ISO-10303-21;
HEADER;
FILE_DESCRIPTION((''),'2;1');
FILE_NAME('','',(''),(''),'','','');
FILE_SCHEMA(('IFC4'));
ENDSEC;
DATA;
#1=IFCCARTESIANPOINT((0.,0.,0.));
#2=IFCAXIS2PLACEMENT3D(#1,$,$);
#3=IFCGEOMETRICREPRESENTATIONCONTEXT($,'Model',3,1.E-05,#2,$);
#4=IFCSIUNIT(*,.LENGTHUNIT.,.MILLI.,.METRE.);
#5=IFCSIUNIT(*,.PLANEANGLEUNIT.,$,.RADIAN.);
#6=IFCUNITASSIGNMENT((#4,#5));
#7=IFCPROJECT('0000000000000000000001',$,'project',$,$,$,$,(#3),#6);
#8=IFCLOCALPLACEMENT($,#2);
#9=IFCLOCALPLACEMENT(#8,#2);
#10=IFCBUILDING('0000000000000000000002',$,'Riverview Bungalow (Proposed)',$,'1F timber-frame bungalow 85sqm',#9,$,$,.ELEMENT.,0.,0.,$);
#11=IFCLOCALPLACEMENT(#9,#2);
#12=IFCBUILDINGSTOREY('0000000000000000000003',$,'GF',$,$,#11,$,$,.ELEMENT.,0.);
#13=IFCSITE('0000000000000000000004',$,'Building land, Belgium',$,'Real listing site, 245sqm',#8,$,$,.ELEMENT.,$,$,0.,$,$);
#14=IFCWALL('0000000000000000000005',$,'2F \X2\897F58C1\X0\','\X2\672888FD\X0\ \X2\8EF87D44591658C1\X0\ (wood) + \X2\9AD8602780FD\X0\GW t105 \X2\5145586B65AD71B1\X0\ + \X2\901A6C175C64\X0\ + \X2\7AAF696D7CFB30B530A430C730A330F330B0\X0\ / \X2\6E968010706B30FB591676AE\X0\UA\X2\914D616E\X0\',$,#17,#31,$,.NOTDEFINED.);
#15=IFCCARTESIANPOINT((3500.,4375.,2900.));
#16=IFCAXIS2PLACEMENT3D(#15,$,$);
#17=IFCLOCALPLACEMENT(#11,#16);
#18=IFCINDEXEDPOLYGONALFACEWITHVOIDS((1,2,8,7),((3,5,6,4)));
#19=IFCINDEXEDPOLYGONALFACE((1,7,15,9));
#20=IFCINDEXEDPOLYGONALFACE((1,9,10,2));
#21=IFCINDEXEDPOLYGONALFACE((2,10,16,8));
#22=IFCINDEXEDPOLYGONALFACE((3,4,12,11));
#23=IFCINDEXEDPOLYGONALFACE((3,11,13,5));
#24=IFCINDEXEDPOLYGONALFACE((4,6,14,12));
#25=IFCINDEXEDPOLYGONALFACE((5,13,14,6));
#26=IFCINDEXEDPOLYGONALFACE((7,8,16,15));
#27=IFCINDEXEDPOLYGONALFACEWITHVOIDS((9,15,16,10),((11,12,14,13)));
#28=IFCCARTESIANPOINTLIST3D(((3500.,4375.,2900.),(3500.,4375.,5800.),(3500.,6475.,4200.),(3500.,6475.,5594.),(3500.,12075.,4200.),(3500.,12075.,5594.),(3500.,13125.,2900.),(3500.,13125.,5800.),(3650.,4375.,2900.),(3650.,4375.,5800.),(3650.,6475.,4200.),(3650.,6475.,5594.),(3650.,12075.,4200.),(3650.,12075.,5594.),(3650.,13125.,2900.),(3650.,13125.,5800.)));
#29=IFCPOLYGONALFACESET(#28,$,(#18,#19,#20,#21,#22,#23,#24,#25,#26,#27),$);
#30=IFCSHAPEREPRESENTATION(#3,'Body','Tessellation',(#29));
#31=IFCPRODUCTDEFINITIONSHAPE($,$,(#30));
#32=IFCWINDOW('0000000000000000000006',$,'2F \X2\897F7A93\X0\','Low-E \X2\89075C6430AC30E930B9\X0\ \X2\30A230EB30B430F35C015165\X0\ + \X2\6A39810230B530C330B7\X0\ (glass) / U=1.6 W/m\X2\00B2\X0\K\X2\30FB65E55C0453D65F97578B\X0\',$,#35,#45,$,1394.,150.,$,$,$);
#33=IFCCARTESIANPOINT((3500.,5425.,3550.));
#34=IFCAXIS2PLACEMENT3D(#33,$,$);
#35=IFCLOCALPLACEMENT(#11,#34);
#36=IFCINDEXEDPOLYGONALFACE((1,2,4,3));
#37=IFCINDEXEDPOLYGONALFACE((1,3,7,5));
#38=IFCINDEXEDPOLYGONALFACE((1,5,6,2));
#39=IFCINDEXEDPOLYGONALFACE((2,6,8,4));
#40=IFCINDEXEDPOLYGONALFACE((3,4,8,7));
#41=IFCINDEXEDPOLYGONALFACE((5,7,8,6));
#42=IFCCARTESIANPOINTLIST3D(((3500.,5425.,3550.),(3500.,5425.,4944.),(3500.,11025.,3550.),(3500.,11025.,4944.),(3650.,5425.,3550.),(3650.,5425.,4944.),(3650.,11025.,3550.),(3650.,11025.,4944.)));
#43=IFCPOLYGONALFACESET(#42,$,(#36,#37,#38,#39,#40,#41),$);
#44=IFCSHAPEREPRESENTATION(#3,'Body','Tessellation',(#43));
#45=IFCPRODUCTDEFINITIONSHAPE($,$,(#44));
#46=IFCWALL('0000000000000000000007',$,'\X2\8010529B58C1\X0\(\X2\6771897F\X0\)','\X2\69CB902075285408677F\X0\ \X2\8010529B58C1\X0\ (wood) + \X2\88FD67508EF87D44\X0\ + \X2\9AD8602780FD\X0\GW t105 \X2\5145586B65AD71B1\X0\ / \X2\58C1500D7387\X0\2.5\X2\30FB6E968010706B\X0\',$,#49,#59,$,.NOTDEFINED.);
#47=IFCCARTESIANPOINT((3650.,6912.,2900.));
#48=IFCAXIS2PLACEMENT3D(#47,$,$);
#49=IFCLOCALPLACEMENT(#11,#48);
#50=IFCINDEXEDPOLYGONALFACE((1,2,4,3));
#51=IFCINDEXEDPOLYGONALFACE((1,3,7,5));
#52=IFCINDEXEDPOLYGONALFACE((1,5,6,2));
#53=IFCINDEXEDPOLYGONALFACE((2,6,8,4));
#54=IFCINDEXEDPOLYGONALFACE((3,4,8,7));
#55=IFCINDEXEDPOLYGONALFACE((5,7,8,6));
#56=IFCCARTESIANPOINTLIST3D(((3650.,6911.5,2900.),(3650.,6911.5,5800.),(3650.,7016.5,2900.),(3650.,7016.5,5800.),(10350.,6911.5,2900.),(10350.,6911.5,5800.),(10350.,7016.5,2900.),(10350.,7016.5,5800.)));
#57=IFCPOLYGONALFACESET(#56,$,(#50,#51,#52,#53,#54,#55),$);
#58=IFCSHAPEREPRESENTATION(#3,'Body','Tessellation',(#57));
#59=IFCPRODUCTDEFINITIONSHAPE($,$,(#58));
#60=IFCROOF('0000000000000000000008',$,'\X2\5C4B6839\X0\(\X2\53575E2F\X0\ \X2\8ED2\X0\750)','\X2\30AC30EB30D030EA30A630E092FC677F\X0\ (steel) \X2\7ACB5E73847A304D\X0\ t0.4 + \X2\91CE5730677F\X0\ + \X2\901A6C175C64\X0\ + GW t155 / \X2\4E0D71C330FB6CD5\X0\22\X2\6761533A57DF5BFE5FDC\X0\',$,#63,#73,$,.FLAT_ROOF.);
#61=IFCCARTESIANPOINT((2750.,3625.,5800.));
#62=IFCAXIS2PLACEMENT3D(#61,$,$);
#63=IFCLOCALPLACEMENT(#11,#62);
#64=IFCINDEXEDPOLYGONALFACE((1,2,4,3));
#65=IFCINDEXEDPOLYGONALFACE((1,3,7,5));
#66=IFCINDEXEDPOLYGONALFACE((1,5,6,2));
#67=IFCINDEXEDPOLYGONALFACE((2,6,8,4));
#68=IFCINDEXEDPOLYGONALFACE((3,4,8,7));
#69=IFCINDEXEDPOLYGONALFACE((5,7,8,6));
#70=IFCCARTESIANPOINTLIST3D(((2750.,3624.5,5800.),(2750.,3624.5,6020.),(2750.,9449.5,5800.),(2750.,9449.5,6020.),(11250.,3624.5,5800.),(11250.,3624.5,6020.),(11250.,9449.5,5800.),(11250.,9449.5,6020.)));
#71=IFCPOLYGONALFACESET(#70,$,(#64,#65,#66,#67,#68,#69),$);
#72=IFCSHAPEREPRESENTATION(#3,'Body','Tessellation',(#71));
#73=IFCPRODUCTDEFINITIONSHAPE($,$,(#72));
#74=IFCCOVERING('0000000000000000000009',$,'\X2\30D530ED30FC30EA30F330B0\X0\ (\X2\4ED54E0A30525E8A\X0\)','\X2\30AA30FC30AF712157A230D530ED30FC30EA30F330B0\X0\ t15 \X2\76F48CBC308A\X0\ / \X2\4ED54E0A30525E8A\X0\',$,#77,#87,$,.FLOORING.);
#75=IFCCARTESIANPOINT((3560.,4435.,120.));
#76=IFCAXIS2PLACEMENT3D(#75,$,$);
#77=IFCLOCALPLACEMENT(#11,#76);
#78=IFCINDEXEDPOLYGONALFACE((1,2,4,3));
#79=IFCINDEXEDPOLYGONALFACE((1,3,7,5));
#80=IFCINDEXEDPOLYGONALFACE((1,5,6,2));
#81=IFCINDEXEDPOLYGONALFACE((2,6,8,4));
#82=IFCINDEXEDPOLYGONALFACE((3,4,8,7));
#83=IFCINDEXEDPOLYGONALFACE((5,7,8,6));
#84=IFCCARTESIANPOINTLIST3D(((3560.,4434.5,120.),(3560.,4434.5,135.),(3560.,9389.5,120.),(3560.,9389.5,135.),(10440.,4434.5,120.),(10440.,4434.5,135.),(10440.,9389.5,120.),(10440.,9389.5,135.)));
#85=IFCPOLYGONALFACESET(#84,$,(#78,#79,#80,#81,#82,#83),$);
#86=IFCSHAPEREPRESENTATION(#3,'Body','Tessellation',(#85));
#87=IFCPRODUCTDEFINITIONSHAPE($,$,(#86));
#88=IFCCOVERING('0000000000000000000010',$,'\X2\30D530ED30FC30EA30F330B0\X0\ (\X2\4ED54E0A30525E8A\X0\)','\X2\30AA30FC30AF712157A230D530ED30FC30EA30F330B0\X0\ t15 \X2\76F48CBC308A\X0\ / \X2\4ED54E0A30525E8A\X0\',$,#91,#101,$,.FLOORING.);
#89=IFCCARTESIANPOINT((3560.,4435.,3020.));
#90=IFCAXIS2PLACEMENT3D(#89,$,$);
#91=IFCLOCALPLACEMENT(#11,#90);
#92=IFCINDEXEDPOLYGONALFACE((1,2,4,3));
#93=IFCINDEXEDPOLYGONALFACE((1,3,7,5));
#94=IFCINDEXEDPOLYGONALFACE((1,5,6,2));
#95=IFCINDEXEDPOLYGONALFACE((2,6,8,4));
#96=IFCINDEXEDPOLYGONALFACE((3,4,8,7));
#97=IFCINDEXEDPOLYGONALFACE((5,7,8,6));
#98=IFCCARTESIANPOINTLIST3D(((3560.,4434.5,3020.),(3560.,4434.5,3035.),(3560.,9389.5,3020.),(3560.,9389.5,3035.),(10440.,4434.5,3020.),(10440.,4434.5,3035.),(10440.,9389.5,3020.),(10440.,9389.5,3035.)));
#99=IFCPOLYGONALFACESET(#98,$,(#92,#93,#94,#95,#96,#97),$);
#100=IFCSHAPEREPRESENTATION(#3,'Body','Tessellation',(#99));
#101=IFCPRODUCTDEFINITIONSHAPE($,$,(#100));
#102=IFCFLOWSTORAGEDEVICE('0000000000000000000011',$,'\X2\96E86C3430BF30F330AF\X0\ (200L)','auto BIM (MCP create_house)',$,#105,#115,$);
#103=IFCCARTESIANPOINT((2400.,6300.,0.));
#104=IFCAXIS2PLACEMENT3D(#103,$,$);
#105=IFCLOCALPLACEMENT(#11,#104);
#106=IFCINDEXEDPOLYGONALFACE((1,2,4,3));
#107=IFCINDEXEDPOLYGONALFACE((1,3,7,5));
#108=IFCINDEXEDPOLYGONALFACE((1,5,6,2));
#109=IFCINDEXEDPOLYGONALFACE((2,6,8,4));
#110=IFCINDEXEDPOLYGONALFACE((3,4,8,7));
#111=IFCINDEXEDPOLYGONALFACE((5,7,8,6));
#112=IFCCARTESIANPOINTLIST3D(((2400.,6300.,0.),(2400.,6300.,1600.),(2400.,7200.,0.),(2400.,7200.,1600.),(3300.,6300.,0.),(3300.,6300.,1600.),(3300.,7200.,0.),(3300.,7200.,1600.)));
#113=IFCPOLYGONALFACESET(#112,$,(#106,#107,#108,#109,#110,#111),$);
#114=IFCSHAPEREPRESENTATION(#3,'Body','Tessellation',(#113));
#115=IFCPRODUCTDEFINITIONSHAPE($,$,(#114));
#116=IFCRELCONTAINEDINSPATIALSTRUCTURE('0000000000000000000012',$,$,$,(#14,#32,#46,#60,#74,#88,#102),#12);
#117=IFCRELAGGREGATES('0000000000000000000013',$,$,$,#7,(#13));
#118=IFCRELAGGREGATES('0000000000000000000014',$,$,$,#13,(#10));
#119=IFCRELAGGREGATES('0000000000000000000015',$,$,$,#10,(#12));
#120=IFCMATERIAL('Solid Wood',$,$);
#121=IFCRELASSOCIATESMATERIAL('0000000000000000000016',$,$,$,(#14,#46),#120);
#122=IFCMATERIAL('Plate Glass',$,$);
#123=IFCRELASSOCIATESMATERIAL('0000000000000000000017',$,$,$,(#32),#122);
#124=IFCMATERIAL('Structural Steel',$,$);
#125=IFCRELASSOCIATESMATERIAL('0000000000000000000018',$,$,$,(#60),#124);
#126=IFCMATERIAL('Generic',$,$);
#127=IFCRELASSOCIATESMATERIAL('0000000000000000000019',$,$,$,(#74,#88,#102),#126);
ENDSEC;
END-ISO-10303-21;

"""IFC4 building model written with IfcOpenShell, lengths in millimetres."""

from ifc_helpers import new_model, si_unit, frame, frame_2d, origin, place, context, project, spatial, rectangle, extrude, material, element, fill, save


model = new_model("IFC4")

# Units and contexts
model_context = context("Model", 3, precision=1e-05, world=origin())
ifc_project = project(units=[si_unit("LENGTHUNIT", "METRE", prefix="MILLI"), si_unit("PLANEANGLEUNIT", "RADIAN")], contexts=[model_context])

# Site, building, storey
site_placement = place(None, origin())
site = spatial("IfcSite", under=ifc_project, at=site_placement, Name="Building land, Belgium", ObjectType="Real listing site, 245sqm", CompositionType="ELEMENT", RefElevation=0.0)
building_placement = place(site_placement, origin())
building = spatial("IfcBuilding", under=site, at=building_placement, Name="Riverview Bungalow (Proposed)", ObjectType="1F timber-frame bungalow 85sqm", CompositionType="ELEMENT", ElevationOfRefHeight=0.0, ElevationOfTerrain=0.0)
storey_placement = place(building_placement, origin())
storey = spatial("IfcBuildingStorey", under=building, at=storey_placement, Name="GF", CompositionType="ELEMENT", Elevation=0.0)

# Shared definitions
ifc_material_1 = material(Name="Solid Wood")
ifc_material_2 = material(Name="Generic")

# Shared definitions
ifc_material_3 = material(Name="Plate Glass")

# Wall, opening, window
wall_1_placement = place(storey_placement, frame((3500.0, 4375.0, 2900.0)))
wall_1 = element("IfcWall", 1, at=wall_1_placement, inside=storey, material=ifc_material_1, Name="2F 西壁", Description="木製 軸組外壁 (wood) + 高性能GW t105 充填断熱 + 通気層 + 窯業系サイディング / 準耐火・外皮UA配慮", PredefinedType="NOTDEFINED", context=model_context, shape_type="SweptSolid", body=[
    extrude(rectangle(XDim=150.0, YDim=8750.0, at=frame_2d((75.0, 4375.0))), frame((3500.0, 4375.0, 2900.0)), (0.0, 0.0, 1.0), 2900.0),
])
opening_1_placement = place(storey_placement, frame((3500.0, 5425.0, 3550.0)))
opening_1 = element("IfcOpeningElement", 2, at=opening_1_placement, cuts=wall_1, PredefinedType="NOTDEFINED", context=model_context, shape_type="SweptSolid", body=[
    extrude(rectangle(XDim=150.0, YDim=5600.0, at=frame_2d((75.0, 2800.0))), frame((3500.0, 5425.0, 3550.0)), (0.0, 0.0, 1.0), 1394.0),
])
window_1_placement = place(storey_placement, frame((3500.0, 5425.0, 3550.0)))
window_1 = element("IfcWindow", 3, at=window_1_placement, inside=storey, material=ifc_material_3, Name="2F 西窓", Description="Low-E 複層ガラス アルゴン封入 + 樹脂サッシ (glass) / U=1.6 W/m²K・日射取得型", OverallHeight=1394.0, OverallWidth=150.0, context=model_context, shape_type="SweptSolid", body=[
    extrude(rectangle(XDim=150.0, YDim=5600.0, at=frame_2d((75.0, 2800.0))), frame((3500.0, 5425.0, 3550.0)), (0.0, 0.0, 1.0), 1394.0),
])
fill(opening_1, window_1)

# Wall
wall_2_placement = place(storey_placement, frame((3650.0, 6912.0, 2900.0)))
element("IfcWall", 4, at=wall_2_placement, inside=storey, material=ifc_material_1, Name="耐力壁(東西)", Description="構造用合板 耐力壁 (wood) + 製材軸組 + 高性能GW t105 充填断熱 / 壁倍率2.5・準耐火", PredefinedType="NOTDEFINED", context=model_context, shape_type="SweptSolid", body=[
    extrude(rectangle(XDim=6700.0, YDim=105.0, at=frame_2d((3350.0, 52.0))), frame((3650.0, 6912.0, 2900.0)), (0.0, 0.0, 1.0), 2900.0),
])

# Roof
ifc_material_4 = material(Name="Structural Steel")
for number, where, name in (
    (5, (2750.0, 3625.0, 5800.0), "屋根(南帯 軒750)"),
):
    element("IfcRoof", number, at=place(storey_placement, frame(where)), inside=storey, material=ifc_material_4, Name=name, Description="ガルバリウム鋼板 (steel) 立平葺き t0.4 + 野地板 + 通気層 + GW t155 / 不燃・法22条区域対応", PredefinedType="FLAT_ROOF", context=model_context, shape_type="SweptSolid", body=[
        extrude(rectangle(XDim=8500.0, YDim=5825.0, at=frame_2d((4250.0, 2912.0))), frame((2750.0, 3625.0, 5800.0)), (0.0, 0.0, 1.0), 220.0),
    ])

# Coverings
covering_1_placement = place(storey_placement, frame((3560.0, 4435.0, 120.0)))
element("IfcCovering", 6, at=covering_1_placement, inside=storey, material=ifc_material_2, Name="フローリング (仕上げ床)", Description="オーク無垢フローリング t15 直貼り / 仕上げ床", PredefinedType="FLOORING", context=model_context, shape_type="SweptSolid", body=[
    extrude(rectangle(XDim=6880.0, YDim=4955.0, at=frame_2d((3440.0, 2477.0))), frame((3560.0, 4435.0, 120.0)), (0.0, 0.0, 1.0), 15.0),
])
covering_2_placement = place(storey_placement, frame((3560.0, 4435.0, 3020.0)))
element("IfcCovering", 7, at=covering_2_placement, inside=storey, material=ifc_material_2, Name="フローリング (仕上げ床)", Description="オーク無垢フローリング t15 直貼り / 仕上げ床", PredefinedType="FLOORING", context=model_context, shape_type="SweptSolid", body=[
    extrude(rectangle(XDim=6880.0, YDim=4955.0, at=frame_2d((3440.0, 2477.0))), frame((3560.0, 4435.0, 3020.0)), (0.0, 0.0, 1.0), 15.0),
])

# Flow storage device
flow_storage_device_placement = place(storey_placement, frame((2400.0, 6300.0, 0.0)))
element("IfcFlowStorageDevice", 8, at=flow_storage_device_placement, inside=storey, material=ifc_material_2, Name="雨水タンク (200L)", Description="auto BIM (MCP create_house)", context=model_context, shape_type="SweptSolid", body=[
    extrude(rectangle(XDim=900.0, YDim=900.0, at=frame_2d((450.0, 450.0))), frame((2400.0, 6300.0, 0.0)), (0.0, 0.0, 1.0), 1600.0),
])

save(model, "model.ifc")
